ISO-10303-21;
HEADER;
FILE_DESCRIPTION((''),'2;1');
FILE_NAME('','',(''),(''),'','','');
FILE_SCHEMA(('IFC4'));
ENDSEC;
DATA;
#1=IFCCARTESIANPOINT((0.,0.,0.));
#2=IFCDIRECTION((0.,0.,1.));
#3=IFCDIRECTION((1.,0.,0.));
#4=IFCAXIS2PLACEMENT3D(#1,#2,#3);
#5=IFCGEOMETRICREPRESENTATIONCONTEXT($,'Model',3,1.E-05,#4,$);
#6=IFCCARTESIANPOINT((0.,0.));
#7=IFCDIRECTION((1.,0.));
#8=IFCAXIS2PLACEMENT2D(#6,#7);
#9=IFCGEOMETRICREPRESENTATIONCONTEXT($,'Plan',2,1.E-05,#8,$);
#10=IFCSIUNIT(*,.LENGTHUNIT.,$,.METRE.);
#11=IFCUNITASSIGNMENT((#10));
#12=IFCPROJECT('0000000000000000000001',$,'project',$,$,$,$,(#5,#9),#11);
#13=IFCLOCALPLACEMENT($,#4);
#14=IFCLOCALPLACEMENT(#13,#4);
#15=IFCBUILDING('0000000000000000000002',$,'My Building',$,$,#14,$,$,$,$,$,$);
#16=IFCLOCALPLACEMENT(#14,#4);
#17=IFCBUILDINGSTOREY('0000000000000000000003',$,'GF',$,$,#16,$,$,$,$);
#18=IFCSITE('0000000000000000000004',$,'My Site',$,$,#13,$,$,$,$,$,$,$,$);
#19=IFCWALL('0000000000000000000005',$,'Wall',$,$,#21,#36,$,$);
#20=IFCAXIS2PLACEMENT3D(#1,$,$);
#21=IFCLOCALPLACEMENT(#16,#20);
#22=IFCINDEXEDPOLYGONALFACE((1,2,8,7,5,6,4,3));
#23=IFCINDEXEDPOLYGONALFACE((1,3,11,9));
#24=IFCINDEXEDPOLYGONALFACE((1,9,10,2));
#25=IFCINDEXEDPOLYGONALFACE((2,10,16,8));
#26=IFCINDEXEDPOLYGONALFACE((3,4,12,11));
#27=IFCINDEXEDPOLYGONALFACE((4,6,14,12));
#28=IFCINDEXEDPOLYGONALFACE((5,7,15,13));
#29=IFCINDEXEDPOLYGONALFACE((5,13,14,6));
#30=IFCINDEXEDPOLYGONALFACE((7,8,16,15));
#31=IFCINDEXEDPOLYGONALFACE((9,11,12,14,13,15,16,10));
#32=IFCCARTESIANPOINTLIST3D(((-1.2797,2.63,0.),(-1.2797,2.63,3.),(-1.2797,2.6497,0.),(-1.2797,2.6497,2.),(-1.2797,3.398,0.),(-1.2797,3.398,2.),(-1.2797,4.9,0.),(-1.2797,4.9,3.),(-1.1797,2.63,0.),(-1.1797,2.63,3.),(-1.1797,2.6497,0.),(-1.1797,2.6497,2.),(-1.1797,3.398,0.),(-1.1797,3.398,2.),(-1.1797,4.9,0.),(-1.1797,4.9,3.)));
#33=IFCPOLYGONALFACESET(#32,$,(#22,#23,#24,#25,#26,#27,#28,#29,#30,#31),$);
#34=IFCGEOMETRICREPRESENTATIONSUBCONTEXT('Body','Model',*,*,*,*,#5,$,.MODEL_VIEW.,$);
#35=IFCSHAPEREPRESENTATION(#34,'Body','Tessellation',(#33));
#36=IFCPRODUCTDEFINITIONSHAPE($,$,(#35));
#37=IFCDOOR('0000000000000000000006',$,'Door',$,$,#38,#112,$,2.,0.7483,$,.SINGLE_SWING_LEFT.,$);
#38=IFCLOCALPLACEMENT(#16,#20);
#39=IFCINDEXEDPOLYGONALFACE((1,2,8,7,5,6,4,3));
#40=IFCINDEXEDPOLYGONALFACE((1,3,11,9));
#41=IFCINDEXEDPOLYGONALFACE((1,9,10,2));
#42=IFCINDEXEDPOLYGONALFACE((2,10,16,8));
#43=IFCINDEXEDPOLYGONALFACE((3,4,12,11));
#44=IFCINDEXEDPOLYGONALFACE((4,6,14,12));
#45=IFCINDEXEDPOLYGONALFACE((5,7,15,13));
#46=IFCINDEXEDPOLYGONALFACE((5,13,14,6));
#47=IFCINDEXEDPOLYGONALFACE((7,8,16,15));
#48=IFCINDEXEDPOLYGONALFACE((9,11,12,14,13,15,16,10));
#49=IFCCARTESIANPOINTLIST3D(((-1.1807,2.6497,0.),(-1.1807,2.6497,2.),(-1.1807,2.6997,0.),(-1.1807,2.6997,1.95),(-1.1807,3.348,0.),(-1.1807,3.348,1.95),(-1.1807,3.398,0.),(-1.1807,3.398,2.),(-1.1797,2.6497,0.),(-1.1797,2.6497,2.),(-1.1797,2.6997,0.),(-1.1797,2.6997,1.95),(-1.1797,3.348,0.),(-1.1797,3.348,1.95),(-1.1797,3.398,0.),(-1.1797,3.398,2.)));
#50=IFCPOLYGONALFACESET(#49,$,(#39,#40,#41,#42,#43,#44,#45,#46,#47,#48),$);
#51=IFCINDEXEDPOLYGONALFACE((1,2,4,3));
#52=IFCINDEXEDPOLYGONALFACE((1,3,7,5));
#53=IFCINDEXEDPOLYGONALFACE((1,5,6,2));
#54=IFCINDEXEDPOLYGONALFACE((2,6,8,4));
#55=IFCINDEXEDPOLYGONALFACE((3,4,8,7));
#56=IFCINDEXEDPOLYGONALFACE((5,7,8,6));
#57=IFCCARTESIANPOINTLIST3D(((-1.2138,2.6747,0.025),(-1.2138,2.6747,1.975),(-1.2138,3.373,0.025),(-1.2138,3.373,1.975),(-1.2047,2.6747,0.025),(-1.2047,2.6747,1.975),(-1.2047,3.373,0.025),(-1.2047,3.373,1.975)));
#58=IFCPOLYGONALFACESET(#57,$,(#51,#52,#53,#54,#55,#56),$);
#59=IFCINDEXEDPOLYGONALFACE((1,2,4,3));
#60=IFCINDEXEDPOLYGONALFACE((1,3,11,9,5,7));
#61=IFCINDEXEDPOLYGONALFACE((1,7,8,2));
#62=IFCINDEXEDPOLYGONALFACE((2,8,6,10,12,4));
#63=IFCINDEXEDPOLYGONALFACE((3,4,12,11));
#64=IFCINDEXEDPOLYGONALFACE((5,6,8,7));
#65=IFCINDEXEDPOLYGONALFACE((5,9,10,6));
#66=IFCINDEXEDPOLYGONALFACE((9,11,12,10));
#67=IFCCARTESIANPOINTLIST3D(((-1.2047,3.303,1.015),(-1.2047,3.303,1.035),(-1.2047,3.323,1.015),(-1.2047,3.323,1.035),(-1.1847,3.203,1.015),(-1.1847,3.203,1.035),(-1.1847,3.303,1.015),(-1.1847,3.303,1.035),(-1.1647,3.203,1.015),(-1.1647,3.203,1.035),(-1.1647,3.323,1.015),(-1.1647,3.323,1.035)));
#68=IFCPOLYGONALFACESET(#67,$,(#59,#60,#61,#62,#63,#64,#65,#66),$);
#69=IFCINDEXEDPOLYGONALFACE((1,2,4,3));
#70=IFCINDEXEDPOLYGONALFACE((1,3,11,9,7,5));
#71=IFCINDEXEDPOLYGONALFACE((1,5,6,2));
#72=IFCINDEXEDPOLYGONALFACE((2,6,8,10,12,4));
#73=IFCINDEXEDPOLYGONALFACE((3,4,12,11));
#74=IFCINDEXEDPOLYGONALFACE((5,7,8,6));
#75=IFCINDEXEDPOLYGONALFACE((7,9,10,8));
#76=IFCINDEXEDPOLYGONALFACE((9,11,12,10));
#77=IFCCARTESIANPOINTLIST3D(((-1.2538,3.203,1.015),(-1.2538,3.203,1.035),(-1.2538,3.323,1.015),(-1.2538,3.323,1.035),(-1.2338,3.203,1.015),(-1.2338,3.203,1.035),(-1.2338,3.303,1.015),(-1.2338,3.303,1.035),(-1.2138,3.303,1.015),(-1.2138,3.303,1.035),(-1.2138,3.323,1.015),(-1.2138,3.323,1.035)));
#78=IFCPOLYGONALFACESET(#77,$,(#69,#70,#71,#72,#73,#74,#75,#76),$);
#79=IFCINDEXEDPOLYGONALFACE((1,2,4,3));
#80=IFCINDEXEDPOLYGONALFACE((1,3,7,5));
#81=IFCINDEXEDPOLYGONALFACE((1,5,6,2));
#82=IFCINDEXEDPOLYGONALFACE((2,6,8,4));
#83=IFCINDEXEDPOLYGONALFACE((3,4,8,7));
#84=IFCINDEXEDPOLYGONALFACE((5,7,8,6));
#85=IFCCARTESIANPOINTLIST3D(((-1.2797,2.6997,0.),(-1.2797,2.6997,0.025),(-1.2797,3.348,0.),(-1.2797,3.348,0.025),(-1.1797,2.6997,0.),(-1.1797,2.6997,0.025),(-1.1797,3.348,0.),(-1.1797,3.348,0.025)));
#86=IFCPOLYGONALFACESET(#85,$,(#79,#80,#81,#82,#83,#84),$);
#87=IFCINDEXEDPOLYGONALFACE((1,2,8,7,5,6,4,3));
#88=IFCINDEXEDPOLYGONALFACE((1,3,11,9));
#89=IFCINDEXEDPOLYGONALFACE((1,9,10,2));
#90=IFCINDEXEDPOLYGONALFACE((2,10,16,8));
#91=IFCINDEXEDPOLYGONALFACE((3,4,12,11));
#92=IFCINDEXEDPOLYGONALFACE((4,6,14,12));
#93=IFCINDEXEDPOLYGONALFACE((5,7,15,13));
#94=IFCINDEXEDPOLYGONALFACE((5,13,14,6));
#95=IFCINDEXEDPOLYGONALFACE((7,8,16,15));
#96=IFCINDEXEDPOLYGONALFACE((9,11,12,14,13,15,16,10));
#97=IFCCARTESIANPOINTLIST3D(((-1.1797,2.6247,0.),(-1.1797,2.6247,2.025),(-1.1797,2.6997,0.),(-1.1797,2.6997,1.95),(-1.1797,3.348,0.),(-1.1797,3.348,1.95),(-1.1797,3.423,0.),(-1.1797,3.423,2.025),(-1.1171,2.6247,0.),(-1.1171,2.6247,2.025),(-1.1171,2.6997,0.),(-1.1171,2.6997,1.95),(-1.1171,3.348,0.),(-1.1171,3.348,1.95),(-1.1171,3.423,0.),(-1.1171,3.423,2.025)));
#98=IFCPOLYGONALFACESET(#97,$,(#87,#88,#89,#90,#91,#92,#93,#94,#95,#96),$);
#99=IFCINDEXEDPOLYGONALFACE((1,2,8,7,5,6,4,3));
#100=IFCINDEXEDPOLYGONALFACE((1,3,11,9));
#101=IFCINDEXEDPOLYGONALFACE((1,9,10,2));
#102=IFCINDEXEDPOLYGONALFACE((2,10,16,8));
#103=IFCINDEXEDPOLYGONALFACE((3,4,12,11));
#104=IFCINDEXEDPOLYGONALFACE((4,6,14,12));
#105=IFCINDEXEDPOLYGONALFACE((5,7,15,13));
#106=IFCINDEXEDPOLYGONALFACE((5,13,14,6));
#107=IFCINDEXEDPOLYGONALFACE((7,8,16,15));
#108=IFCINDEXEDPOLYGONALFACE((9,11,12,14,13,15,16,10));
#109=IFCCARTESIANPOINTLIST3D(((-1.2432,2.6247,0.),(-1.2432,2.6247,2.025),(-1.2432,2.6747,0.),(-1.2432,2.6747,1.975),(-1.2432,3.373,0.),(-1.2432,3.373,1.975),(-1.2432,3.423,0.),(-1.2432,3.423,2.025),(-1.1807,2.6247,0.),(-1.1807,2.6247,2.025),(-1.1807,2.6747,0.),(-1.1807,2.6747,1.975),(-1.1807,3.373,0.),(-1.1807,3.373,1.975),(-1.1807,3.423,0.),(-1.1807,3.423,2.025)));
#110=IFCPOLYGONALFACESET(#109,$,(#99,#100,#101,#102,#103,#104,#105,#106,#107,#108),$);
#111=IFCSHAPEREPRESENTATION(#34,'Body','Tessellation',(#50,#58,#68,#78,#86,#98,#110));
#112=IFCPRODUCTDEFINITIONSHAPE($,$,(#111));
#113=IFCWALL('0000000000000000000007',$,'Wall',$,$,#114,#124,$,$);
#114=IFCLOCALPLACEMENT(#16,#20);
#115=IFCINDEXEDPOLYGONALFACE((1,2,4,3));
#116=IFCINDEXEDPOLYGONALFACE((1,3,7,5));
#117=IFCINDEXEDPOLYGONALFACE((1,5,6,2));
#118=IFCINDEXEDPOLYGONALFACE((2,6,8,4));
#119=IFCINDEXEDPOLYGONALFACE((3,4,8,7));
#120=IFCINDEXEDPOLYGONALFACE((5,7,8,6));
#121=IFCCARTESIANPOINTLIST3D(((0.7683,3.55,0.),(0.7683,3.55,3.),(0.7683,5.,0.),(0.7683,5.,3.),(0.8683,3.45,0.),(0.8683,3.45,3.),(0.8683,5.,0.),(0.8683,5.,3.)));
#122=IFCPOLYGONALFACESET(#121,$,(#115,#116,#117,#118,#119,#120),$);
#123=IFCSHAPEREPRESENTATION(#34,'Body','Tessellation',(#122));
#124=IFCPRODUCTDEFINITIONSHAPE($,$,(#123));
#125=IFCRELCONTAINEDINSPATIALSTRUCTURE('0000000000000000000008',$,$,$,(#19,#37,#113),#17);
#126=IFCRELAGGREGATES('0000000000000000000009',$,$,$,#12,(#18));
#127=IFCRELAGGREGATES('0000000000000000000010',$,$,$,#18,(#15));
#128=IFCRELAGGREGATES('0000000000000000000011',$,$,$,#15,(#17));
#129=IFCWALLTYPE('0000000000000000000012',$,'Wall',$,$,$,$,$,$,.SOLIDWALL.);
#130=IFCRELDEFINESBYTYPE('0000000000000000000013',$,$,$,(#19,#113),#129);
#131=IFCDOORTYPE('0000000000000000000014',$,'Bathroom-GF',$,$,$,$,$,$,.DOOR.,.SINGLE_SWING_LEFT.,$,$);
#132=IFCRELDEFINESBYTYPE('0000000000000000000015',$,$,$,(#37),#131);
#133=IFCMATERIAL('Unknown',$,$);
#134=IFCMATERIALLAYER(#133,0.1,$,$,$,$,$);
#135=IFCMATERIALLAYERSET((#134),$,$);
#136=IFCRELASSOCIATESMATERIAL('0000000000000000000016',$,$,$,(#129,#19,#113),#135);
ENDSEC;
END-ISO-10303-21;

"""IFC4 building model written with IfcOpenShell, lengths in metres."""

from ifc_helpers import new_model, entity, si_unit, frame, origin_with_axes, origin_2d_with_axis, place, context, subcontext, project, spatial, line, indexed_curve, outline, extrude, shape, source, transform, mapped, material, layer, layer_set, layer_usage, type_object, type_shapes, element, fill, save


model = new_model("IFC4")

# Units and contexts
model_context = context("Model", 3, precision=1e-05, world=origin_with_axes())
plan_context = context("Plan", 2, precision=1e-05, world=origin_2d_with_axis())
body_context_1 = subcontext(model_context, "Body", "Model", "MODEL_VIEW")
body_context_2 = subcontext(plan_context, "Body", "Plan", "PLAN_VIEW")
ifc_project = project(units=[si_unit("LENGTHUNIT", "METRE")], contexts=[model_context, plan_context])

# Site, building, storey
site_placement = place(None, origin_with_axes())
site = spatial("IfcSite", under=ifc_project, at=site_placement, Name="My Site")
building_placement = place(site_placement, origin_with_axes())
building = spatial("IfcBuilding", under=site, at=building_placement, Name="My Building")
storey_placement = place(building_placement, origin_with_axes())
storey = spatial("IfcBuildingStorey", under=building, at=storey_placement, Name="GF")

# Shared definitions
ifc_material_1 = material(Name="Unknown")
ifc_layer = layer(ifc_material_1, 0.1)
ifc_layer_set = layer_set([ifc_layer])
wall_type = type_object("IfcWallType", Name="Wall", PredefinedType="SOLIDWALL", material=ifc_layer_set)

# Wall, opening, door
ifc_layer_usage_1 = layer_usage(ifc_layer_set, "AXIS2", "POSITIVE", 0.0)
wall_1_placement = place(storey_placement, frame((-1.1797, 2.63, 0.0), z_axis=(0.0, 0.0, 1.0), x_axis=(0.0, 1.0, 0.0)))
wall_1 = element("IfcWall", 1, at=wall_1_placement, inside=storey, type_object=wall_type, material=ifc_layer_usage_1, Name="Wall", context=body_context_1, shape_type="SweptSolid", body=[
    extrude(outline(indexed_curve([(0.0, 0.0), (0.0, 0.1), (2.27, 0.1), (2.27, 0.0)], segments=[line(1, 2, 3, 4, 1)])), origin_with_axes(), (0.0, 0.0, 1.0), 3.0),
])
shared_shape_1 = source(origin_with_axes(), body_context_1, "Body", "SweptSolid", [
    extrude(outline(indexed_curve([(0.0, 0.0), (0.7483, 0.0), (0.7483, 2.0), (0.0, 2.0)], segments=[line(1, 2, 3, 4, 1)])), frame((0.0, -0.6, 0.0), z_axis=(0.0, -1.0, 0.0), x_axis=(1.0, 0.0, 0.0)), (0.0, 0.0, -1.0), 1.2),
])
opening_1_placement = place(wall_1_placement, frame((0.0197, 0.0, 0.0), z_axis=(0.0, 0.0, 1.0), x_axis=(1.0, 0.0, 0.0)))
opening_1 = element("IfcOpeningElement", 2, at=opening_1_placement, cuts=wall_1, PredefinedType="OPENING", context=body_context_1, shape_type="MappedRepresentation", body=[
    mapped(shared_shape_1, transform((0.0, 0.0, 0.0), x_axis=(1.0, 0.0, 0.0), y_axis=(0.0, 1.0, 0.0), z_axis=(0.0, 0.0, 1.0), scale=1.0)),
])
door_type_1 = type_object("IfcDoorType", Name="Bathroom-GF", OperationType="SINGLE_SWING_LEFT", PredefinedType="DOOR")
shared_shape_2 = source(origin_with_axes(), body_context_1, "Body", "SweptSolid", [
    extrude(outline(indexed_curve([(0.0, 0.0), (0.0, 2.0), (0.7483, 2.0), (0.7483, 0.0), (0.6983, 0.0), (0.6983, 1.95), (0.05, 1.95), (0.05, 0.0)], segments=[line(1, 2, 3, 4, 5, 6, 7, 8, 1)])), frame((0.0, 0.0, 0.0), z_axis=(0.0, -1.0, 0.0), x_axis=(1.0, 0.0, 0.0)), (0.0, 0.0, -1.0), 0.001),
    extrude(outline(indexed_curve([(0.0, 0.0), (0.6983, 0.0), (0.6983, 0.0092), (0.0, 0.0092)], segments=[line(1, 2, 3, 4, 1)])), frame((0.025, 0.025, 0.025), z_axis=(0.0, 0.0, 1.0), x_axis=(1.0, 0.0, 0.0)), (0.0, 0.0, 1.0), 1.95),
    extrude(outline(indexed_curve([(0.0, 0.0), (0.0, -0.04), (-0.12, -0.04), (-0.12, -0.02), (-0.02, -0.02), (-0.02, 0.0)], segments=[line(1, 2, 3, 4, 5, 6, 1)])), frame((0.6733, 0.025, 1.015), z_axis=(0.0, 0.0, 1.0), x_axis=(1.0, 0.0, 0.0)), (0.0, 0.0, 1.0), 0.02),
    extrude(outline(indexed_curve([(0.0, 0.0), (0.0, 0.04), (-0.12, 0.04), (-0.12, 0.02), (-0.02, 0.02), (-0.02, 0.0)], segments=[line(1, 2, 3, 4, 5, 6, 1)])), frame((0.6733, 0.0342, 1.015), z_axis=(0.0, 0.0, 1.0), x_axis=(1.0, 0.0, 0.0)), (0.0, 0.0, 1.0), 0.02),
    extrude(outline(indexed_curve([(0.0, 0.0), (0.6483, 0.0), (0.6483, 0.1), (0.0, 0.1)], segments=[line(1, 2, 3, 4, 1)])), frame((0.05, 0.0, 0.0), z_axis=(0.0, 0.0, 1.0), x_axis=(1.0, 0.0, 0.0)), (0.0, 0.0, 1.0), 0.025),
    extrude(outline(indexed_curve([(0.0, 0.0), (0.0, 2.025), (0.7983, 2.025), (0.7983, 0.0), (0.7233, 0.0), (0.7233, 1.95), (0.075, 1.95), (0.075, 0.0)], segments=[line(1, 2, 3, 4, 5, 6, 7, 8, 1)])), frame((-0.025, -0.0626, 0.0), z_axis=(0.0, -1.0, 0.0), x_axis=(1.0, 0.0, 0.0)), (0.0, 0.0, -1.0), 0.0626),
    extrude(outline(indexed_curve([(0.0, 0.0), (0.0, 2.025), (0.7983, 2.025), (0.7983, 0.0), (0.7483, 0.0), (0.7483, 1.975), (0.05, 1.975), (0.05, 0.0)], segments=[line(1, 2, 3, 4, 5, 6, 7, 8, 1)])), frame((-0.025, 0.001, 0.0), z_axis=(0.0, -1.0, 0.0), x_axis=(1.0, 0.0, 0.0)), (0.0, 0.0, -1.0), 0.0626),
])
shared_shape_3 = source(origin_with_axes(), body_context_2, "Body", "Curve2D", [
    entity("IfcIndexedPolyCurve", entity("IfcCartesianPointList2D", [[0.0, 0.0], [0.05, 0.0], [0.05, 0.001], [0.0, 0.001]]), [entity("IfcLineIndex", [1, 2, 3, 4, 1])]),
    entity("IfcIndexedPolyCurve", entity("IfcCartesianPointList2D", [[0.7483, 0.0], [0.6983, 0.0], [0.6983, 0.001], [0.7483, 0.001]]), [entity("IfcLineIndex", [1, 2, 3, 4, 1])]),
    entity("IfcTrimmedCurve", entity("IfcEllipse", entity("IfcAxis2Placement2D", entity("IfcCartesianPoint", [0.0342, 0.001]), entity("IfcDirection", [1.0, 0.0])), 0.6891, 0.6983), [entity("IfcCartesianPoint", [0.7233, 0.001])], [entity("IfcCartesianPoint", [0.0342, 0.6993])], True, "CARTESIAN"),
    entity("IfcIndexedPolyCurve", entity("IfcCartesianPointList2D", [[0.025, 0.001], [0.0342, 0.001], [0.0342, 0.6993], [0.025, 0.6993]]), [entity("IfcLineIndex", [1, 2, 3, 4, 1])]),
])
type_shapes(door_type_1, [shared_shape_2, shared_shape_3])
door_1_placement = place(opening_1_placement, frame((0.0, 0.0, 0.0), z_axis=(0.0, 0.0, 1.0), x_axis=(1.0, 0.0, 0.0)))
door_1 = element("IfcDoor", 3, at=door_1_placement, inside=storey, type_object=door_type_1, Name="Door", OperationType="SINGLE_SWING_LEFT", OverallHeight=2.0, OverallWidth=0.7483, shapes=[
    shape(body_context_1, "Body", "MappedRepresentation", [mapped(shared_shape_2, transform((0.0, 0.0, 0.0), x_axis=(1.0, 0.0, 0.0), y_axis=(0.0, 1.0, 0.0), z_axis=(0.0, 0.0, 1.0), scale=1.0))]),
    shape(body_context_2, "Body", "MappedRepresentation", [mapped(shared_shape_3, transform((0.0, 0.0, 0.0), x_axis=(1.0, 0.0, 0.0), y_axis=(0.0, 1.0, 0.0), z_axis=(0.0, 0.0, 1.0), scale=1.0))]),
])
fill(opening_1, door_1)

# Wall
ifc_layer_usage_2 = layer_usage(ifc_layer_set, "AXIS2", "POSITIVE", 0.0)
wall_2_placement = place(storey_placement, frame((0.7683, 5.0, 0.0), z_axis=(0.0, 0.0, 1.0), x_axis=(0.0, -1.0, 0.0)))
element("IfcWall", 4, at=wall_2_placement, inside=storey, type_object=wall_type, material=ifc_layer_usage_2, Name="Wall", context=body_context_1, shape_type="SweptSolid", body=[
    extrude(outline(indexed_curve([(0.0, 0.0), (0.0, 0.1), (1.55, 0.1), (1.45, 0.0)], segments=[line(1, 2, 3, 4, 1)])), origin_with_axes(), (0.0, 0.0, 1.0), 3.0),
])

save(model, "model.ifc")
